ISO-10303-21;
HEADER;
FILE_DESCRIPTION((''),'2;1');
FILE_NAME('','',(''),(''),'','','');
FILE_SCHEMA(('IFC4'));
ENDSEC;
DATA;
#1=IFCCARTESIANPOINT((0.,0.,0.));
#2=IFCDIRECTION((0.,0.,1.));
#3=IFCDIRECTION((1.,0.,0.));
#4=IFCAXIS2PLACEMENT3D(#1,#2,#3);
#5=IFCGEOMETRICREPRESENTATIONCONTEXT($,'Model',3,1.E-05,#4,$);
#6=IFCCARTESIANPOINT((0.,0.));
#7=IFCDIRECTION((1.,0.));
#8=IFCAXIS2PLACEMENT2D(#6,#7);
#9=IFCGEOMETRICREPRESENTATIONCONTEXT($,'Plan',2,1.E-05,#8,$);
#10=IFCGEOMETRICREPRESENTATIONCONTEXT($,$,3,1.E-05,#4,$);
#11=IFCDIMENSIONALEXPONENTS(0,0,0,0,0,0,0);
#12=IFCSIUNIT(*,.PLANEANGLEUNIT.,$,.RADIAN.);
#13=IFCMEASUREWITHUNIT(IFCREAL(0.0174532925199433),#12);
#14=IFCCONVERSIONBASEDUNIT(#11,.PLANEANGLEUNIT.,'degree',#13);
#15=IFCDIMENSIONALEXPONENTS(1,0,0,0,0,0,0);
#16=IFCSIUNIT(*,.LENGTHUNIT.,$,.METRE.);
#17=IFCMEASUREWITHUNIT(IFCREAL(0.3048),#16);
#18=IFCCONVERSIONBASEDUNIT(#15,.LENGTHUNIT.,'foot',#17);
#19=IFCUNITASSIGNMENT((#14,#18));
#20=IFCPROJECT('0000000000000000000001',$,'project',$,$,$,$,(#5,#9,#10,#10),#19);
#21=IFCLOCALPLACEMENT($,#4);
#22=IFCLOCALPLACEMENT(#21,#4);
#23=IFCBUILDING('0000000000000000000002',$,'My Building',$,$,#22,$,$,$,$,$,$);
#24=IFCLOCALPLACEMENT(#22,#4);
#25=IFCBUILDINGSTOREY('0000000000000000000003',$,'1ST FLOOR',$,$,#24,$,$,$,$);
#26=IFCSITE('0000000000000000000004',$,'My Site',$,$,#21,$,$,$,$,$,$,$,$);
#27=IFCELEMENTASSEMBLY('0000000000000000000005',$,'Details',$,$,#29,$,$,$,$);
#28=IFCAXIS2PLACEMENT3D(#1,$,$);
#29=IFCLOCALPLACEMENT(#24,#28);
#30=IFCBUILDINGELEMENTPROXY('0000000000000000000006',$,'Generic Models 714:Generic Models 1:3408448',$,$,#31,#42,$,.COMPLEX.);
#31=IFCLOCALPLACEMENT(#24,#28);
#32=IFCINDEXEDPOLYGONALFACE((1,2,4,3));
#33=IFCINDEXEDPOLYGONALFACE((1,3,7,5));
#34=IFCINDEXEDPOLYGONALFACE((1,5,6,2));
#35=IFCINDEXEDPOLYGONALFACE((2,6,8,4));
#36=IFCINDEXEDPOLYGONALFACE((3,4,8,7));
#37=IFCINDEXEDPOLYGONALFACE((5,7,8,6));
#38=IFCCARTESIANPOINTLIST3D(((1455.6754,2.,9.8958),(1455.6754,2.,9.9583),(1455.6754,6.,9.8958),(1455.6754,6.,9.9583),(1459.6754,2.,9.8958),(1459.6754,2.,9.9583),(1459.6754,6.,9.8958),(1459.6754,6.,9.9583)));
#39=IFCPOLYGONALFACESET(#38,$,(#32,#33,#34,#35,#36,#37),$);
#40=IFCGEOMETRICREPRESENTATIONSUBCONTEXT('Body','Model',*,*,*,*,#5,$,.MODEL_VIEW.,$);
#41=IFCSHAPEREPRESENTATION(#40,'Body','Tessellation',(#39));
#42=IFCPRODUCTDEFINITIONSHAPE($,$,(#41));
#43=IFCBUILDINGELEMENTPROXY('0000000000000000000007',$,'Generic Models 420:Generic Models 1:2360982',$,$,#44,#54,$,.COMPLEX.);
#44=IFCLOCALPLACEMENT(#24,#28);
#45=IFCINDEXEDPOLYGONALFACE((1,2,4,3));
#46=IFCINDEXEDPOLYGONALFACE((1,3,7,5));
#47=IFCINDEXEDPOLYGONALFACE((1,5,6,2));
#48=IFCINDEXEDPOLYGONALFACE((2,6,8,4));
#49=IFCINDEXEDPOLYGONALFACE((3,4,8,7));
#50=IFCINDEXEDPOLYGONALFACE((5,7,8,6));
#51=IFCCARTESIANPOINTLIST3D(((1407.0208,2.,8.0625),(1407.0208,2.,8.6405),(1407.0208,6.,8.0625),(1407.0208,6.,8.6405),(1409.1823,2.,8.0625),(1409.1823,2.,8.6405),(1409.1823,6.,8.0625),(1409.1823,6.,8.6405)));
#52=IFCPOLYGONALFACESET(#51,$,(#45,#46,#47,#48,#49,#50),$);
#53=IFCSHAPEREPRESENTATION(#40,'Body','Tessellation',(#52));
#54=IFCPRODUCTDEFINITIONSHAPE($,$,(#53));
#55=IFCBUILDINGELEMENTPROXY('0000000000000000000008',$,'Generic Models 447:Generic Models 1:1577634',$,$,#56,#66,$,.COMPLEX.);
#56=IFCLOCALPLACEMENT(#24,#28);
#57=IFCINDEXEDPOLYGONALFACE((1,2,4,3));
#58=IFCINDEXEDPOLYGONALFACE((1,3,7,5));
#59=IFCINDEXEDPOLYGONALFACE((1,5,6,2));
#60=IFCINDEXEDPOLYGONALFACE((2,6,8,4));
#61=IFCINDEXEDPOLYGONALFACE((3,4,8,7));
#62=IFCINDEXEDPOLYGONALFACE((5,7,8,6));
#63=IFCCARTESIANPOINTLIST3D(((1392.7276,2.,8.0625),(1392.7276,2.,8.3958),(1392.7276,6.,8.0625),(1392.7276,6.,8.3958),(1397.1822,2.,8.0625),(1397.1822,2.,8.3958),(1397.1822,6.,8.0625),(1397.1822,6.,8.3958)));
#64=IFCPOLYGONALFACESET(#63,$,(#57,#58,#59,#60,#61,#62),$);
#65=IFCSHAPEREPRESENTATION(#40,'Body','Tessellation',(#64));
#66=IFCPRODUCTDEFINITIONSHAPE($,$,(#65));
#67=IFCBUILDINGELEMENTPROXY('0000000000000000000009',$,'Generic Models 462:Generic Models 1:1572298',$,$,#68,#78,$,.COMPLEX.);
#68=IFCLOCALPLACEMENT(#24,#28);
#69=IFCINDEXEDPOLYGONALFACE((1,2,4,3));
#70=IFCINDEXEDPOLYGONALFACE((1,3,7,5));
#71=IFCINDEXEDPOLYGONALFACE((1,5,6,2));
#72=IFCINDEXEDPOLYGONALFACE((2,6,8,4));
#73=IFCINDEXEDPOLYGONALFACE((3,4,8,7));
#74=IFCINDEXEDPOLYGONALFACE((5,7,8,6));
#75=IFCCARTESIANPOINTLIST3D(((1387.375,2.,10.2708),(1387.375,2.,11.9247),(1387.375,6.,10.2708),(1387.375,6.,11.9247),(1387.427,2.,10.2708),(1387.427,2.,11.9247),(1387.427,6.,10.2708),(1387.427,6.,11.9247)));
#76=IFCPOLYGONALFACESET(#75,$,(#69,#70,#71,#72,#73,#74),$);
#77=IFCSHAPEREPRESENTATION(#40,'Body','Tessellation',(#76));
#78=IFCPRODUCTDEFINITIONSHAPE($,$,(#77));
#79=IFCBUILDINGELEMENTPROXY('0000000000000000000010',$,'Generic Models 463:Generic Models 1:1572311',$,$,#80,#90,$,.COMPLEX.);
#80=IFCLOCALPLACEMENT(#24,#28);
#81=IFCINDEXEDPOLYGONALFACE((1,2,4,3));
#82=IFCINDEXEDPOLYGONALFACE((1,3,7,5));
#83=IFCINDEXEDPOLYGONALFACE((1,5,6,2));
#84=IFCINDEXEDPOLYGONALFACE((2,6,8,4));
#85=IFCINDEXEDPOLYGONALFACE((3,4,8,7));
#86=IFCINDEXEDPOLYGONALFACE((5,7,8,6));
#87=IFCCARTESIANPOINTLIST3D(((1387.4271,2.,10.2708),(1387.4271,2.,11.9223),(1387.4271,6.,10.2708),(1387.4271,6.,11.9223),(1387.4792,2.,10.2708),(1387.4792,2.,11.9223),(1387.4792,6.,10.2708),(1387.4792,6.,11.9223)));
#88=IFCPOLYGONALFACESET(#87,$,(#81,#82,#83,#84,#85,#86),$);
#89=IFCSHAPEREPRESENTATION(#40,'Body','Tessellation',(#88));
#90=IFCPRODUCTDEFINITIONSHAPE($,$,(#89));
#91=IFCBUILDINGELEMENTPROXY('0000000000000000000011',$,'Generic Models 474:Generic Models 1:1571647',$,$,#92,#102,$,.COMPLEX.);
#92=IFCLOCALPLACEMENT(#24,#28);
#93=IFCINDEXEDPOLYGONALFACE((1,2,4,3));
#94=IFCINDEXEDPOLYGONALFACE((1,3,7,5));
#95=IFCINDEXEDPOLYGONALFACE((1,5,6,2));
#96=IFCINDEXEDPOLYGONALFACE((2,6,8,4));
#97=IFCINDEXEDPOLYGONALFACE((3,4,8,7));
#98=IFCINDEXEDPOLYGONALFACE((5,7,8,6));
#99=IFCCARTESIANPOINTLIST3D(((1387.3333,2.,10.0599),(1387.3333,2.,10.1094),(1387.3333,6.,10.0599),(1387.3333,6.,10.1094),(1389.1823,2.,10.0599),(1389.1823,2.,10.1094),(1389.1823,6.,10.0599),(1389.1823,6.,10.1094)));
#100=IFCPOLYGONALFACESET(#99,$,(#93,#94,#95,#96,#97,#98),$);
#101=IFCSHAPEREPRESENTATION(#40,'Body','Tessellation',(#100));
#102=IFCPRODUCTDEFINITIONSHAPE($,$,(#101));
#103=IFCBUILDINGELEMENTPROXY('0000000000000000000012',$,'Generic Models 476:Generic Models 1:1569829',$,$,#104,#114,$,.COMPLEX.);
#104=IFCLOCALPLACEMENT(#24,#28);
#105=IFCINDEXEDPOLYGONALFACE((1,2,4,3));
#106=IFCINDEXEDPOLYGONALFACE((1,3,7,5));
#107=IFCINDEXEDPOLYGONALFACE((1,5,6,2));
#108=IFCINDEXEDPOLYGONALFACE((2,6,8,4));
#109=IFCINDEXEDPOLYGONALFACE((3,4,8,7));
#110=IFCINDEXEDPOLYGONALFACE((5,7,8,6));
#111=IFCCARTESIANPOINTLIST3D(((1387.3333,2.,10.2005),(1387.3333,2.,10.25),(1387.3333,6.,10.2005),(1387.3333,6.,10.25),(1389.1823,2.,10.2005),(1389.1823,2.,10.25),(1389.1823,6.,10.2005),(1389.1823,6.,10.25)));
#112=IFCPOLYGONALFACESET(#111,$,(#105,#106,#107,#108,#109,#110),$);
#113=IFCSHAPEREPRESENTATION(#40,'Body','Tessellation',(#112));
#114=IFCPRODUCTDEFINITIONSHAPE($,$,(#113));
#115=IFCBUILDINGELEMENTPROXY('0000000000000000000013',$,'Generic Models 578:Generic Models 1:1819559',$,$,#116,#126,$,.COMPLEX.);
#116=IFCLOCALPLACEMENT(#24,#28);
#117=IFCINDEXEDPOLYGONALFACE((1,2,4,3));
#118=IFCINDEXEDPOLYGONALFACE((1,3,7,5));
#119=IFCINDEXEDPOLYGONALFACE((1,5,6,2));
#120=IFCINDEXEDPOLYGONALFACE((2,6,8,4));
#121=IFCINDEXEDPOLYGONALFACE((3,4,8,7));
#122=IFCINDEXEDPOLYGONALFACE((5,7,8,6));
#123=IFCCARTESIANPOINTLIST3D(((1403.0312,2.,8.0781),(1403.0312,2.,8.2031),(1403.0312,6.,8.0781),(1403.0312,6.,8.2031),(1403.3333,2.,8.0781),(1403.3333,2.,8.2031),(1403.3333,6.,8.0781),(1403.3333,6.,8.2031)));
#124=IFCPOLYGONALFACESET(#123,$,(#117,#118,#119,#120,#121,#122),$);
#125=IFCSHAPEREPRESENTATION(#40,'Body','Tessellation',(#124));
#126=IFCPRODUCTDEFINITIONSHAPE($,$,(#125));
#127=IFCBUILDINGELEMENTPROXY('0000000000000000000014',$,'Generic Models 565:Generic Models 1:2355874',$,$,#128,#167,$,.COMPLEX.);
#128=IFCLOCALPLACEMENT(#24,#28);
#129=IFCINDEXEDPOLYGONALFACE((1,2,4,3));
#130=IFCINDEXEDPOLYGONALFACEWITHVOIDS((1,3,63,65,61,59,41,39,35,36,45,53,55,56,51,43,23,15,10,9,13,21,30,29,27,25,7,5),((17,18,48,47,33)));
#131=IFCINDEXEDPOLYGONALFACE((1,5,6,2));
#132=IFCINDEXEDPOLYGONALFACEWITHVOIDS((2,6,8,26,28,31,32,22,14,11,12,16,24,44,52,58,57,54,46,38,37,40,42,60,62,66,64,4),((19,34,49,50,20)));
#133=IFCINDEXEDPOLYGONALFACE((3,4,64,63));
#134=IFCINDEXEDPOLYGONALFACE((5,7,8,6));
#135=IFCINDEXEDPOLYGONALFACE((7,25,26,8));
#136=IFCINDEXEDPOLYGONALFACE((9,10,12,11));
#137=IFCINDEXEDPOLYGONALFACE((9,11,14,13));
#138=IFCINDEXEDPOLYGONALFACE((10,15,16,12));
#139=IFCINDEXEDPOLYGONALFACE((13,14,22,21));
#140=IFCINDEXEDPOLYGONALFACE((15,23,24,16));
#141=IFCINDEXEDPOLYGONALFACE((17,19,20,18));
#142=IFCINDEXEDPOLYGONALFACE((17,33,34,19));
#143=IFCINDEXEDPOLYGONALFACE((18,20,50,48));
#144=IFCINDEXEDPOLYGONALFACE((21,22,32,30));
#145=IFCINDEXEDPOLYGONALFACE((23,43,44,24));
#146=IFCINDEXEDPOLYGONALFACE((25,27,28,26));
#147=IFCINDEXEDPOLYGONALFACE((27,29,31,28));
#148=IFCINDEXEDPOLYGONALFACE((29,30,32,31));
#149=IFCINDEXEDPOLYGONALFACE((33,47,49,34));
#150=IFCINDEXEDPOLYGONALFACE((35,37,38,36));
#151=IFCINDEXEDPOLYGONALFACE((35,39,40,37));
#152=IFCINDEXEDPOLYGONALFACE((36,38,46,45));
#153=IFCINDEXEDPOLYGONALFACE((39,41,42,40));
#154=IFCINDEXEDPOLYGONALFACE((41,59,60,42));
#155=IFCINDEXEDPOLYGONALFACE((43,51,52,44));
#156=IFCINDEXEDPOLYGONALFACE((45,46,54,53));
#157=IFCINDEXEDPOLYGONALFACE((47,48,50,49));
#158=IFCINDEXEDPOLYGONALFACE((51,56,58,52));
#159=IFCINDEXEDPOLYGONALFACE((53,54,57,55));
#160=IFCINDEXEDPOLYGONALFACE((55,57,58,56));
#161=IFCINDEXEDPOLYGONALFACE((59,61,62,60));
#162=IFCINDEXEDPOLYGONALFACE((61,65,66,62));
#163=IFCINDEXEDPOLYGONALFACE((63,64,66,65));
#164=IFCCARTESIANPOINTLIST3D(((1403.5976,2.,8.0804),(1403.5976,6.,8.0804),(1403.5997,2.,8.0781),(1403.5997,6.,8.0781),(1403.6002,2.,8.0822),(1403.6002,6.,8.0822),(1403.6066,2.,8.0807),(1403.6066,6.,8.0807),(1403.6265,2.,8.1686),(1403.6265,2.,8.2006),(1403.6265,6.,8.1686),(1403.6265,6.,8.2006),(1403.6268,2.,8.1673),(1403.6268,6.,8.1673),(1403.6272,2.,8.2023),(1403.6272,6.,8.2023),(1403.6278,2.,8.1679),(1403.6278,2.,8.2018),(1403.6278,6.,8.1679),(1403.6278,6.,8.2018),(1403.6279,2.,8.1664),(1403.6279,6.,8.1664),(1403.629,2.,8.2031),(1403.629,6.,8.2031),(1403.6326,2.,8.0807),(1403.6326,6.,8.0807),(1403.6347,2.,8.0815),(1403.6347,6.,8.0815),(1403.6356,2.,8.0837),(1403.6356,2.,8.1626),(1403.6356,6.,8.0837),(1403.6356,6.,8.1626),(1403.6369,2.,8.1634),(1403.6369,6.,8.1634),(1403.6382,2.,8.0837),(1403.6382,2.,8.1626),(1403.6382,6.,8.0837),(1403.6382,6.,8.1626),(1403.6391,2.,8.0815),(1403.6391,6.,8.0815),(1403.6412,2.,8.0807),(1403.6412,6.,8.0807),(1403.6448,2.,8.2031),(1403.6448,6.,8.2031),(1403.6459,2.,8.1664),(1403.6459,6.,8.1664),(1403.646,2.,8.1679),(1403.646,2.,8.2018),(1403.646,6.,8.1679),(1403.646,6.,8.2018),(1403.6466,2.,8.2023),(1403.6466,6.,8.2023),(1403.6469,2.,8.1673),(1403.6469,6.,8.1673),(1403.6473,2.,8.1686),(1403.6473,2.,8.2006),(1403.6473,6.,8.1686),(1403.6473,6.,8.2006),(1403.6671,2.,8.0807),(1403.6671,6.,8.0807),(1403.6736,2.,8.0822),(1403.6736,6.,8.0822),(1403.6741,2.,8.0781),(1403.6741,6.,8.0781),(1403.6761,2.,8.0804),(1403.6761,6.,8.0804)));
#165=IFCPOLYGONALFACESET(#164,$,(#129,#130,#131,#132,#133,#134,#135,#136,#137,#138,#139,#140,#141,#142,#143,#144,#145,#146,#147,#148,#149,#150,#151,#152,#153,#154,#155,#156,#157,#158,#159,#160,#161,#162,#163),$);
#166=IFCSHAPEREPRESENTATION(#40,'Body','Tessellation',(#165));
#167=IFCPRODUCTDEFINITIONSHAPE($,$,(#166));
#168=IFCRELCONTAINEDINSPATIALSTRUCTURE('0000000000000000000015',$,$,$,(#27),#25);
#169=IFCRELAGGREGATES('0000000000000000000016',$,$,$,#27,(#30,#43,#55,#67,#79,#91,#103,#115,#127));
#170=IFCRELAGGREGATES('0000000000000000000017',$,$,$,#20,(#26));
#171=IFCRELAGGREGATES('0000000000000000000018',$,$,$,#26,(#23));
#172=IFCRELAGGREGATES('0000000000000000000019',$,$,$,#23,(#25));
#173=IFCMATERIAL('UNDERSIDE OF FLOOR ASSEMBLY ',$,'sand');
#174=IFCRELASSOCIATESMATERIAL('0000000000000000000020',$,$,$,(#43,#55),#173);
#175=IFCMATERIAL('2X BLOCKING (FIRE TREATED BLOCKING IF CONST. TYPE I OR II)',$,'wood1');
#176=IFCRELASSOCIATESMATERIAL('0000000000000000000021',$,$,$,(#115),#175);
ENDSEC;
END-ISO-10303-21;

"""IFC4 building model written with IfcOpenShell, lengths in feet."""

from ifc_helpers import new_model, entity, si_unit, converted_unit, frame, origin_with_axes, origin_2d_with_axis, place, context, subcontext, project, spatial, polyline, line, indexed_curve, outline, extrude, material, element, aggregate, save


model = new_model("IFC4")

# Units and contexts
model_context = context("Model", 3, precision=1e-05, world=origin_with_axes())
plan_context = context("Plan", 2, precision=1e-05, world=origin_2d_with_axis())
context_of_model = context(None, 3, precision=1e-05, world=origin_with_axes())
body_context = subcontext(model_context, "Body", "Model", "MODEL_VIEW")
ifc_project = project(units=[converted_unit("PLANEANGLEUNIT", "degree", entity("IfcReal", 0.0174532925199433), si_unit("PLANEANGLEUNIT", "RADIAN"), dimensions=[0, 0, 0, 0, 0, 0, 0]), converted_unit("LENGTHUNIT", "foot", entity("IfcReal", 0.3048), si_unit("LENGTHUNIT", "METRE"), dimensions=[1, 0, 0, 0, 0, 0, 0])], contexts=[model_context, plan_context, context_of_model, context_of_model])

# Site, building, storey
site_placement = place(None, origin_with_axes())
site = spatial("IfcSite", under=ifc_project, at=site_placement, Name="My Site")
building_placement = place(site_placement, origin_with_axes())
building = spatial("IfcBuilding", under=site, at=building_placement, Name="My Building")
storey_placement = place(building_placement, origin_with_axes())
storey = spatial("IfcBuildingStorey", under=building, at=storey_placement, Name="1ST FLOOR")

# Element assembly, building element proxies
assembly_placement = place(storey_placement, origin_with_axes())
assembly = element("IfcElementAssembly", 1, at=assembly_placement, inside=storey, Name="Details")
ifc_material_1 = material(Name="UNDERSIDE OF FLOOR ASSEMBLY ", Category="sand")
proxy_1_placement = place(assembly_placement, frame((1455.6754, 6.0, 9.8958), z_axis=(0.0, -1.0, 0.0), x_axis=(0.0, 0.0, 1.0)))
proxy_1 = element("IfcBuildingElementProxy", 2, at=proxy_1_placement, Name="Generic Models 714:Generic Models 1:3408448", PredefinedType="COMPLEX", context=body_context, shape_type="SweptSolid", body=[
    extrude(outline(indexed_curve([(-0.0313, -2.0), (0.0312, -2.0), (0.0313, 2.0), (-0.0312, 2.0)], segments=[line(4, 1), line(1, 2), line(2, 3), line(3, 4)], self_intersect=False)), frame((0.0313, -2.0, 0.0), z_axis=(0.0, 0.0, -1.0), x_axis=(-1.0, 0.0, 0.0)), (0.0, 0.0, -1.0), 4.0),
])
proxy_2_placement = place(assembly_placement, frame((1407.0208, 6.0, 8.0625), z_axis=(0.0, -1.0, 0.0), x_axis=(0.0, 0.0, 1.0)))
proxy_2 = element("IfcBuildingElementProxy", 3, at=proxy_2_placement, material=ifc_material_1, Name="Generic Models 420:Generic Models 1:2360982", PredefinedType="COMPLEX", context=body_context, shape_type="SweptSolid", body=[
    extrude(outline(polyline([(-0.289, -1.0807), (0.289, -1.0807), (0.289, 1.0807), (-0.289, 1.0807), (-0.289, -1.0807)])), frame((0.289, -1.0807, 0.0), z_axis=(0.0, 0.0, -1.0), x_axis=(1.0, 0.0, 0.0)), (0.0, 0.0, -1.0), 4.0),
])
proxy_3_placement = place(assembly_placement, frame((1392.7276, 6.0, 8.0625), z_axis=(0.0, -1.0, 0.0), x_axis=(0.0, 0.0, 1.0)))
proxy_3 = element("IfcBuildingElementProxy", 4, at=proxy_3_placement, material=ifc_material_1, Name="Generic Models 447:Generic Models 1:1577634", PredefinedType="COMPLEX", context=body_context, shape_type="SweptSolid", body=[
    extrude(outline(indexed_curve([(-2.4546, -0.1667), (2.0, -0.1667), (2.0, 0.1667), (-2.4546, 0.1667)], segments=[line(3, 2), line(2, 1), line(1, 4), line(4, 3)], self_intersect=False)), frame((0.1667, -2.0, 0.0), z_axis=(0.0, 0.0, -1.0), x_axis=(0.0, 1.0, 0.0)), (0.0, 0.0, -1.0), 4.0),
])
proxy_4_placement = place(assembly_placement, frame((1387.375, 6.0, 10.2708), z_axis=(0.0, -1.0, 0.0), x_axis=(0.0, 0.0, 1.0)))
proxy_4 = element("IfcBuildingElementProxy", 5, at=proxy_4_placement, Name="Generic Models 462:Generic Models 1:1572298", PredefinedType="COMPLEX", context=body_context, shape_type="SweptSolid", body=[
    extrude(outline(polyline([(-0.026, -0.8269), (0.026, -0.8269), (0.026, 0.8269), (-0.026, 0.8269), (-0.026, -0.8269)])), frame((0.8269, -0.026, 0.0), z_axis=(0.0, 0.0, -1.0), x_axis=(0.0, 1.0, 0.0)), (0.0, 0.0, -1.0), 4.0),
])
proxy_5_placement = place(assembly_placement, frame((1387.4271, 6.0, 10.2708), z_axis=(0.0, -1.0, 0.0), x_axis=(0.0, 0.0, 1.0)))
proxy_5 = element("IfcBuildingElementProxy", 6, at=proxy_5_placement, Name="Generic Models 463:Generic Models 1:1572311", PredefinedType="COMPLEX", context=body_context, shape_type="SweptSolid", body=[
    extrude(outline(polyline([(-0.026, -0.8258), (0.026, -0.8258), (0.026, 0.8258), (-0.026, 0.8258), (-0.026, -0.8258)])), frame((0.8258, -0.026, 0.0), z_axis=(0.0, 0.0, -1.0), x_axis=(0.0, 1.0, 0.0)), (0.0, 0.0, -1.0), 4.0),
])
proxy_6_placement = place(assembly_placement, frame((1387.3333, 6.0, 10.0599), z_axis=(0.0, -1.0, 0.0), x_axis=(0.0, 0.0, 1.0)))
proxy_6 = element("IfcBuildingElementProxy", 7, at=proxy_6_placement, Name="Generic Models 474:Generic Models 1:1571647", PredefinedType="COMPLEX", context=body_context, shape_type="SweptSolid", body=[
    extrude(outline(polyline([(-0.0247, -0.9245), (0.0247, -0.9245), (0.0247, 0.9245), (-0.0247, 0.9245), (-0.0247, -0.9245)])), frame((0.0247, -0.9245, 0.0), z_axis=(0.0, 0.0, -1.0), x_axis=(-1.0, 0.0, 0.0)), (0.0, 0.0, -1.0), 4.0),
])
proxy_7_placement = place(assembly_placement, frame((1387.3333, 6.0, 10.2005), z_axis=(0.0, -1.0, 0.0), x_axis=(0.0, 0.0, 1.0)))
proxy_7 = element("IfcBuildingElementProxy", 8, at=proxy_7_placement, Name="Generic Models 476:Generic Models 1:1569829", PredefinedType="COMPLEX", context=body_context, shape_type="SweptSolid", body=[
    extrude(outline(polyline([(-0.0247, -0.9245), (0.0247, -0.9245), (0.0247, 0.9245), (-0.0247, 0.9245), (-0.0247, -0.9245)])), frame((0.0247, -0.9245, 0.0), z_axis=(0.0, 0.0, -1.0), x_axis=(-1.0, 0.0, 0.0)), (0.0, 0.0, -1.0), 4.0),
])
ifc_material_2 = material(Name="2X BLOCKING (FIRE TREATED BLOCKING IF CONST. TYPE I OR II)", Category="wood1")
proxy_8_placement = place(assembly_placement, frame((1403.0312, 6.0, 8.0781), z_axis=(0.0, -1.0, 0.0), x_axis=(0.0, 0.0, 1.0)))
proxy_8 = element("IfcBuildingElementProxy", 9, at=proxy_8_placement, material=ifc_material_2, Name="Generic Models 578:Generic Models 1:1819559", PredefinedType="COMPLEX", context=body_context, shape_type="SweptSolid", body=[
    extrude(outline(polyline([(-0.0625, -0.151), (0.0625, -0.151), (0.0625, 0.151), (-0.0625, 0.151), (-0.0625, -0.151)])), frame((0.0625, -0.151, 0.0), z_axis=(0.0, 0.0, -1.0), x_axis=(-1.0, 0.0, 0.0)), (0.0, 0.0, -1.0), 4.0),
])
proxy_9_placement = place(assembly_placement, frame((1403.5976, 6.0, 8.0781), z_axis=(0.0, -1.0, 0.0), x_axis=(0.0, 0.0, 1.0)))
proxy_9 = element("IfcBuildingElementProxy", 10, at=proxy_9_placement, Name="Generic Models 565:Generic Models 1:2355874", PredefinedType="COMPLEX", context=body_context, shape_type="SweptSolid", body=[
    extrude(outline(indexed_curve([(0.0297, 0.0058), (0.0311, 0.006), (0.0627, 0.0015), (0.0643, 0.0005), (0.0648, -0.0014), (0.0625, -0.017), (0.0615, -0.0187), (0.0597, -0.0192), (0.0281, -0.0146), (0.0268, -0.014), (0.0261, -0.0129), (0.0234, -0.0047), (-0.0547, 0.0066), (-0.0569, 0.006), (-0.0581, 0.0041), (-0.0618, -0.0216), (-0.0612, -0.0282), (-0.0634, -0.0305), (-0.0654, -0.0281), (-0.0547, 0.0455), (-0.0522, 0.0472), (-0.0507, 0.0444), (-0.0532, 0.0382), (-0.0569, 0.0126), (-0.0563, 0.0103), (-0.0543, 0.0092), (0.0238, -0.0021), (0.0286, 0.005), (0.0301, 0.0048), (0.0637, 0.0), (0.0611, -0.018), (0.0275, -0.0132), (0.0244, -0.0035)], segments=[line(7, 6), line(6, 5), line(5, 4), line(4, 3), line(3, 2), line(2, 1), line(1, 28), line(28, 27), line(27, 26), line(26, 25), line(25, 24), line(24, 23), line(23, 22), line(22, 21), line(21, 20), line(20, 19), line(19, 18), line(18, 17), line(17, 16), line(16, 15), line(15, 14), line(14, 13), line(13, 12), line(12, 11), line(11, 10), line(10, 9), line(9, 8), line(8, 7)], self_intersect=False), holes=[indexed_curve([(0.0297, 0.0058), (0.0311, 0.006), (0.0627, 0.0015), (0.0643, 0.0005), (0.0648, -0.0014), (0.0625, -0.017), (0.0615, -0.0187), (0.0597, -0.0192), (0.0281, -0.0146), (0.0268, -0.014), (0.0261, -0.0129), (0.0234, -0.0047), (-0.0547, 0.0066), (-0.0569, 0.006), (-0.0581, 0.0041), (-0.0618, -0.0216), (-0.0612, -0.0282), (-0.0634, -0.0305), (-0.0654, -0.0281), (-0.0547, 0.0455), (-0.0522, 0.0472), (-0.0507, 0.0444), (-0.0532, 0.0382), (-0.0569, 0.0126), (-0.0563, 0.0103), (-0.0543, 0.0092), (0.0238, -0.0021), (0.0286, 0.005), (0.0301, 0.0048), (0.0637, 0.0), (0.0611, -0.018), (0.0275, -0.0132), (0.0244, -0.0035)], segments=[line(31, 32), line(32, 33), line(33, 29), line(29, 30), line(30, 31)], self_intersect=False)]), frame((0.0607, -0.0392, 0.0), z_axis=(0.0, 0.0, -1.0), x_axis=(0.989698, -0.14317, 0.0)), (0.0, 0.0, -1.0), 4.0),
])
aggregate(assembly, [proxy_1, proxy_2, proxy_3, proxy_4, proxy_5, proxy_6, proxy_7, proxy_8, proxy_9])

save(model, "model.ifc")
